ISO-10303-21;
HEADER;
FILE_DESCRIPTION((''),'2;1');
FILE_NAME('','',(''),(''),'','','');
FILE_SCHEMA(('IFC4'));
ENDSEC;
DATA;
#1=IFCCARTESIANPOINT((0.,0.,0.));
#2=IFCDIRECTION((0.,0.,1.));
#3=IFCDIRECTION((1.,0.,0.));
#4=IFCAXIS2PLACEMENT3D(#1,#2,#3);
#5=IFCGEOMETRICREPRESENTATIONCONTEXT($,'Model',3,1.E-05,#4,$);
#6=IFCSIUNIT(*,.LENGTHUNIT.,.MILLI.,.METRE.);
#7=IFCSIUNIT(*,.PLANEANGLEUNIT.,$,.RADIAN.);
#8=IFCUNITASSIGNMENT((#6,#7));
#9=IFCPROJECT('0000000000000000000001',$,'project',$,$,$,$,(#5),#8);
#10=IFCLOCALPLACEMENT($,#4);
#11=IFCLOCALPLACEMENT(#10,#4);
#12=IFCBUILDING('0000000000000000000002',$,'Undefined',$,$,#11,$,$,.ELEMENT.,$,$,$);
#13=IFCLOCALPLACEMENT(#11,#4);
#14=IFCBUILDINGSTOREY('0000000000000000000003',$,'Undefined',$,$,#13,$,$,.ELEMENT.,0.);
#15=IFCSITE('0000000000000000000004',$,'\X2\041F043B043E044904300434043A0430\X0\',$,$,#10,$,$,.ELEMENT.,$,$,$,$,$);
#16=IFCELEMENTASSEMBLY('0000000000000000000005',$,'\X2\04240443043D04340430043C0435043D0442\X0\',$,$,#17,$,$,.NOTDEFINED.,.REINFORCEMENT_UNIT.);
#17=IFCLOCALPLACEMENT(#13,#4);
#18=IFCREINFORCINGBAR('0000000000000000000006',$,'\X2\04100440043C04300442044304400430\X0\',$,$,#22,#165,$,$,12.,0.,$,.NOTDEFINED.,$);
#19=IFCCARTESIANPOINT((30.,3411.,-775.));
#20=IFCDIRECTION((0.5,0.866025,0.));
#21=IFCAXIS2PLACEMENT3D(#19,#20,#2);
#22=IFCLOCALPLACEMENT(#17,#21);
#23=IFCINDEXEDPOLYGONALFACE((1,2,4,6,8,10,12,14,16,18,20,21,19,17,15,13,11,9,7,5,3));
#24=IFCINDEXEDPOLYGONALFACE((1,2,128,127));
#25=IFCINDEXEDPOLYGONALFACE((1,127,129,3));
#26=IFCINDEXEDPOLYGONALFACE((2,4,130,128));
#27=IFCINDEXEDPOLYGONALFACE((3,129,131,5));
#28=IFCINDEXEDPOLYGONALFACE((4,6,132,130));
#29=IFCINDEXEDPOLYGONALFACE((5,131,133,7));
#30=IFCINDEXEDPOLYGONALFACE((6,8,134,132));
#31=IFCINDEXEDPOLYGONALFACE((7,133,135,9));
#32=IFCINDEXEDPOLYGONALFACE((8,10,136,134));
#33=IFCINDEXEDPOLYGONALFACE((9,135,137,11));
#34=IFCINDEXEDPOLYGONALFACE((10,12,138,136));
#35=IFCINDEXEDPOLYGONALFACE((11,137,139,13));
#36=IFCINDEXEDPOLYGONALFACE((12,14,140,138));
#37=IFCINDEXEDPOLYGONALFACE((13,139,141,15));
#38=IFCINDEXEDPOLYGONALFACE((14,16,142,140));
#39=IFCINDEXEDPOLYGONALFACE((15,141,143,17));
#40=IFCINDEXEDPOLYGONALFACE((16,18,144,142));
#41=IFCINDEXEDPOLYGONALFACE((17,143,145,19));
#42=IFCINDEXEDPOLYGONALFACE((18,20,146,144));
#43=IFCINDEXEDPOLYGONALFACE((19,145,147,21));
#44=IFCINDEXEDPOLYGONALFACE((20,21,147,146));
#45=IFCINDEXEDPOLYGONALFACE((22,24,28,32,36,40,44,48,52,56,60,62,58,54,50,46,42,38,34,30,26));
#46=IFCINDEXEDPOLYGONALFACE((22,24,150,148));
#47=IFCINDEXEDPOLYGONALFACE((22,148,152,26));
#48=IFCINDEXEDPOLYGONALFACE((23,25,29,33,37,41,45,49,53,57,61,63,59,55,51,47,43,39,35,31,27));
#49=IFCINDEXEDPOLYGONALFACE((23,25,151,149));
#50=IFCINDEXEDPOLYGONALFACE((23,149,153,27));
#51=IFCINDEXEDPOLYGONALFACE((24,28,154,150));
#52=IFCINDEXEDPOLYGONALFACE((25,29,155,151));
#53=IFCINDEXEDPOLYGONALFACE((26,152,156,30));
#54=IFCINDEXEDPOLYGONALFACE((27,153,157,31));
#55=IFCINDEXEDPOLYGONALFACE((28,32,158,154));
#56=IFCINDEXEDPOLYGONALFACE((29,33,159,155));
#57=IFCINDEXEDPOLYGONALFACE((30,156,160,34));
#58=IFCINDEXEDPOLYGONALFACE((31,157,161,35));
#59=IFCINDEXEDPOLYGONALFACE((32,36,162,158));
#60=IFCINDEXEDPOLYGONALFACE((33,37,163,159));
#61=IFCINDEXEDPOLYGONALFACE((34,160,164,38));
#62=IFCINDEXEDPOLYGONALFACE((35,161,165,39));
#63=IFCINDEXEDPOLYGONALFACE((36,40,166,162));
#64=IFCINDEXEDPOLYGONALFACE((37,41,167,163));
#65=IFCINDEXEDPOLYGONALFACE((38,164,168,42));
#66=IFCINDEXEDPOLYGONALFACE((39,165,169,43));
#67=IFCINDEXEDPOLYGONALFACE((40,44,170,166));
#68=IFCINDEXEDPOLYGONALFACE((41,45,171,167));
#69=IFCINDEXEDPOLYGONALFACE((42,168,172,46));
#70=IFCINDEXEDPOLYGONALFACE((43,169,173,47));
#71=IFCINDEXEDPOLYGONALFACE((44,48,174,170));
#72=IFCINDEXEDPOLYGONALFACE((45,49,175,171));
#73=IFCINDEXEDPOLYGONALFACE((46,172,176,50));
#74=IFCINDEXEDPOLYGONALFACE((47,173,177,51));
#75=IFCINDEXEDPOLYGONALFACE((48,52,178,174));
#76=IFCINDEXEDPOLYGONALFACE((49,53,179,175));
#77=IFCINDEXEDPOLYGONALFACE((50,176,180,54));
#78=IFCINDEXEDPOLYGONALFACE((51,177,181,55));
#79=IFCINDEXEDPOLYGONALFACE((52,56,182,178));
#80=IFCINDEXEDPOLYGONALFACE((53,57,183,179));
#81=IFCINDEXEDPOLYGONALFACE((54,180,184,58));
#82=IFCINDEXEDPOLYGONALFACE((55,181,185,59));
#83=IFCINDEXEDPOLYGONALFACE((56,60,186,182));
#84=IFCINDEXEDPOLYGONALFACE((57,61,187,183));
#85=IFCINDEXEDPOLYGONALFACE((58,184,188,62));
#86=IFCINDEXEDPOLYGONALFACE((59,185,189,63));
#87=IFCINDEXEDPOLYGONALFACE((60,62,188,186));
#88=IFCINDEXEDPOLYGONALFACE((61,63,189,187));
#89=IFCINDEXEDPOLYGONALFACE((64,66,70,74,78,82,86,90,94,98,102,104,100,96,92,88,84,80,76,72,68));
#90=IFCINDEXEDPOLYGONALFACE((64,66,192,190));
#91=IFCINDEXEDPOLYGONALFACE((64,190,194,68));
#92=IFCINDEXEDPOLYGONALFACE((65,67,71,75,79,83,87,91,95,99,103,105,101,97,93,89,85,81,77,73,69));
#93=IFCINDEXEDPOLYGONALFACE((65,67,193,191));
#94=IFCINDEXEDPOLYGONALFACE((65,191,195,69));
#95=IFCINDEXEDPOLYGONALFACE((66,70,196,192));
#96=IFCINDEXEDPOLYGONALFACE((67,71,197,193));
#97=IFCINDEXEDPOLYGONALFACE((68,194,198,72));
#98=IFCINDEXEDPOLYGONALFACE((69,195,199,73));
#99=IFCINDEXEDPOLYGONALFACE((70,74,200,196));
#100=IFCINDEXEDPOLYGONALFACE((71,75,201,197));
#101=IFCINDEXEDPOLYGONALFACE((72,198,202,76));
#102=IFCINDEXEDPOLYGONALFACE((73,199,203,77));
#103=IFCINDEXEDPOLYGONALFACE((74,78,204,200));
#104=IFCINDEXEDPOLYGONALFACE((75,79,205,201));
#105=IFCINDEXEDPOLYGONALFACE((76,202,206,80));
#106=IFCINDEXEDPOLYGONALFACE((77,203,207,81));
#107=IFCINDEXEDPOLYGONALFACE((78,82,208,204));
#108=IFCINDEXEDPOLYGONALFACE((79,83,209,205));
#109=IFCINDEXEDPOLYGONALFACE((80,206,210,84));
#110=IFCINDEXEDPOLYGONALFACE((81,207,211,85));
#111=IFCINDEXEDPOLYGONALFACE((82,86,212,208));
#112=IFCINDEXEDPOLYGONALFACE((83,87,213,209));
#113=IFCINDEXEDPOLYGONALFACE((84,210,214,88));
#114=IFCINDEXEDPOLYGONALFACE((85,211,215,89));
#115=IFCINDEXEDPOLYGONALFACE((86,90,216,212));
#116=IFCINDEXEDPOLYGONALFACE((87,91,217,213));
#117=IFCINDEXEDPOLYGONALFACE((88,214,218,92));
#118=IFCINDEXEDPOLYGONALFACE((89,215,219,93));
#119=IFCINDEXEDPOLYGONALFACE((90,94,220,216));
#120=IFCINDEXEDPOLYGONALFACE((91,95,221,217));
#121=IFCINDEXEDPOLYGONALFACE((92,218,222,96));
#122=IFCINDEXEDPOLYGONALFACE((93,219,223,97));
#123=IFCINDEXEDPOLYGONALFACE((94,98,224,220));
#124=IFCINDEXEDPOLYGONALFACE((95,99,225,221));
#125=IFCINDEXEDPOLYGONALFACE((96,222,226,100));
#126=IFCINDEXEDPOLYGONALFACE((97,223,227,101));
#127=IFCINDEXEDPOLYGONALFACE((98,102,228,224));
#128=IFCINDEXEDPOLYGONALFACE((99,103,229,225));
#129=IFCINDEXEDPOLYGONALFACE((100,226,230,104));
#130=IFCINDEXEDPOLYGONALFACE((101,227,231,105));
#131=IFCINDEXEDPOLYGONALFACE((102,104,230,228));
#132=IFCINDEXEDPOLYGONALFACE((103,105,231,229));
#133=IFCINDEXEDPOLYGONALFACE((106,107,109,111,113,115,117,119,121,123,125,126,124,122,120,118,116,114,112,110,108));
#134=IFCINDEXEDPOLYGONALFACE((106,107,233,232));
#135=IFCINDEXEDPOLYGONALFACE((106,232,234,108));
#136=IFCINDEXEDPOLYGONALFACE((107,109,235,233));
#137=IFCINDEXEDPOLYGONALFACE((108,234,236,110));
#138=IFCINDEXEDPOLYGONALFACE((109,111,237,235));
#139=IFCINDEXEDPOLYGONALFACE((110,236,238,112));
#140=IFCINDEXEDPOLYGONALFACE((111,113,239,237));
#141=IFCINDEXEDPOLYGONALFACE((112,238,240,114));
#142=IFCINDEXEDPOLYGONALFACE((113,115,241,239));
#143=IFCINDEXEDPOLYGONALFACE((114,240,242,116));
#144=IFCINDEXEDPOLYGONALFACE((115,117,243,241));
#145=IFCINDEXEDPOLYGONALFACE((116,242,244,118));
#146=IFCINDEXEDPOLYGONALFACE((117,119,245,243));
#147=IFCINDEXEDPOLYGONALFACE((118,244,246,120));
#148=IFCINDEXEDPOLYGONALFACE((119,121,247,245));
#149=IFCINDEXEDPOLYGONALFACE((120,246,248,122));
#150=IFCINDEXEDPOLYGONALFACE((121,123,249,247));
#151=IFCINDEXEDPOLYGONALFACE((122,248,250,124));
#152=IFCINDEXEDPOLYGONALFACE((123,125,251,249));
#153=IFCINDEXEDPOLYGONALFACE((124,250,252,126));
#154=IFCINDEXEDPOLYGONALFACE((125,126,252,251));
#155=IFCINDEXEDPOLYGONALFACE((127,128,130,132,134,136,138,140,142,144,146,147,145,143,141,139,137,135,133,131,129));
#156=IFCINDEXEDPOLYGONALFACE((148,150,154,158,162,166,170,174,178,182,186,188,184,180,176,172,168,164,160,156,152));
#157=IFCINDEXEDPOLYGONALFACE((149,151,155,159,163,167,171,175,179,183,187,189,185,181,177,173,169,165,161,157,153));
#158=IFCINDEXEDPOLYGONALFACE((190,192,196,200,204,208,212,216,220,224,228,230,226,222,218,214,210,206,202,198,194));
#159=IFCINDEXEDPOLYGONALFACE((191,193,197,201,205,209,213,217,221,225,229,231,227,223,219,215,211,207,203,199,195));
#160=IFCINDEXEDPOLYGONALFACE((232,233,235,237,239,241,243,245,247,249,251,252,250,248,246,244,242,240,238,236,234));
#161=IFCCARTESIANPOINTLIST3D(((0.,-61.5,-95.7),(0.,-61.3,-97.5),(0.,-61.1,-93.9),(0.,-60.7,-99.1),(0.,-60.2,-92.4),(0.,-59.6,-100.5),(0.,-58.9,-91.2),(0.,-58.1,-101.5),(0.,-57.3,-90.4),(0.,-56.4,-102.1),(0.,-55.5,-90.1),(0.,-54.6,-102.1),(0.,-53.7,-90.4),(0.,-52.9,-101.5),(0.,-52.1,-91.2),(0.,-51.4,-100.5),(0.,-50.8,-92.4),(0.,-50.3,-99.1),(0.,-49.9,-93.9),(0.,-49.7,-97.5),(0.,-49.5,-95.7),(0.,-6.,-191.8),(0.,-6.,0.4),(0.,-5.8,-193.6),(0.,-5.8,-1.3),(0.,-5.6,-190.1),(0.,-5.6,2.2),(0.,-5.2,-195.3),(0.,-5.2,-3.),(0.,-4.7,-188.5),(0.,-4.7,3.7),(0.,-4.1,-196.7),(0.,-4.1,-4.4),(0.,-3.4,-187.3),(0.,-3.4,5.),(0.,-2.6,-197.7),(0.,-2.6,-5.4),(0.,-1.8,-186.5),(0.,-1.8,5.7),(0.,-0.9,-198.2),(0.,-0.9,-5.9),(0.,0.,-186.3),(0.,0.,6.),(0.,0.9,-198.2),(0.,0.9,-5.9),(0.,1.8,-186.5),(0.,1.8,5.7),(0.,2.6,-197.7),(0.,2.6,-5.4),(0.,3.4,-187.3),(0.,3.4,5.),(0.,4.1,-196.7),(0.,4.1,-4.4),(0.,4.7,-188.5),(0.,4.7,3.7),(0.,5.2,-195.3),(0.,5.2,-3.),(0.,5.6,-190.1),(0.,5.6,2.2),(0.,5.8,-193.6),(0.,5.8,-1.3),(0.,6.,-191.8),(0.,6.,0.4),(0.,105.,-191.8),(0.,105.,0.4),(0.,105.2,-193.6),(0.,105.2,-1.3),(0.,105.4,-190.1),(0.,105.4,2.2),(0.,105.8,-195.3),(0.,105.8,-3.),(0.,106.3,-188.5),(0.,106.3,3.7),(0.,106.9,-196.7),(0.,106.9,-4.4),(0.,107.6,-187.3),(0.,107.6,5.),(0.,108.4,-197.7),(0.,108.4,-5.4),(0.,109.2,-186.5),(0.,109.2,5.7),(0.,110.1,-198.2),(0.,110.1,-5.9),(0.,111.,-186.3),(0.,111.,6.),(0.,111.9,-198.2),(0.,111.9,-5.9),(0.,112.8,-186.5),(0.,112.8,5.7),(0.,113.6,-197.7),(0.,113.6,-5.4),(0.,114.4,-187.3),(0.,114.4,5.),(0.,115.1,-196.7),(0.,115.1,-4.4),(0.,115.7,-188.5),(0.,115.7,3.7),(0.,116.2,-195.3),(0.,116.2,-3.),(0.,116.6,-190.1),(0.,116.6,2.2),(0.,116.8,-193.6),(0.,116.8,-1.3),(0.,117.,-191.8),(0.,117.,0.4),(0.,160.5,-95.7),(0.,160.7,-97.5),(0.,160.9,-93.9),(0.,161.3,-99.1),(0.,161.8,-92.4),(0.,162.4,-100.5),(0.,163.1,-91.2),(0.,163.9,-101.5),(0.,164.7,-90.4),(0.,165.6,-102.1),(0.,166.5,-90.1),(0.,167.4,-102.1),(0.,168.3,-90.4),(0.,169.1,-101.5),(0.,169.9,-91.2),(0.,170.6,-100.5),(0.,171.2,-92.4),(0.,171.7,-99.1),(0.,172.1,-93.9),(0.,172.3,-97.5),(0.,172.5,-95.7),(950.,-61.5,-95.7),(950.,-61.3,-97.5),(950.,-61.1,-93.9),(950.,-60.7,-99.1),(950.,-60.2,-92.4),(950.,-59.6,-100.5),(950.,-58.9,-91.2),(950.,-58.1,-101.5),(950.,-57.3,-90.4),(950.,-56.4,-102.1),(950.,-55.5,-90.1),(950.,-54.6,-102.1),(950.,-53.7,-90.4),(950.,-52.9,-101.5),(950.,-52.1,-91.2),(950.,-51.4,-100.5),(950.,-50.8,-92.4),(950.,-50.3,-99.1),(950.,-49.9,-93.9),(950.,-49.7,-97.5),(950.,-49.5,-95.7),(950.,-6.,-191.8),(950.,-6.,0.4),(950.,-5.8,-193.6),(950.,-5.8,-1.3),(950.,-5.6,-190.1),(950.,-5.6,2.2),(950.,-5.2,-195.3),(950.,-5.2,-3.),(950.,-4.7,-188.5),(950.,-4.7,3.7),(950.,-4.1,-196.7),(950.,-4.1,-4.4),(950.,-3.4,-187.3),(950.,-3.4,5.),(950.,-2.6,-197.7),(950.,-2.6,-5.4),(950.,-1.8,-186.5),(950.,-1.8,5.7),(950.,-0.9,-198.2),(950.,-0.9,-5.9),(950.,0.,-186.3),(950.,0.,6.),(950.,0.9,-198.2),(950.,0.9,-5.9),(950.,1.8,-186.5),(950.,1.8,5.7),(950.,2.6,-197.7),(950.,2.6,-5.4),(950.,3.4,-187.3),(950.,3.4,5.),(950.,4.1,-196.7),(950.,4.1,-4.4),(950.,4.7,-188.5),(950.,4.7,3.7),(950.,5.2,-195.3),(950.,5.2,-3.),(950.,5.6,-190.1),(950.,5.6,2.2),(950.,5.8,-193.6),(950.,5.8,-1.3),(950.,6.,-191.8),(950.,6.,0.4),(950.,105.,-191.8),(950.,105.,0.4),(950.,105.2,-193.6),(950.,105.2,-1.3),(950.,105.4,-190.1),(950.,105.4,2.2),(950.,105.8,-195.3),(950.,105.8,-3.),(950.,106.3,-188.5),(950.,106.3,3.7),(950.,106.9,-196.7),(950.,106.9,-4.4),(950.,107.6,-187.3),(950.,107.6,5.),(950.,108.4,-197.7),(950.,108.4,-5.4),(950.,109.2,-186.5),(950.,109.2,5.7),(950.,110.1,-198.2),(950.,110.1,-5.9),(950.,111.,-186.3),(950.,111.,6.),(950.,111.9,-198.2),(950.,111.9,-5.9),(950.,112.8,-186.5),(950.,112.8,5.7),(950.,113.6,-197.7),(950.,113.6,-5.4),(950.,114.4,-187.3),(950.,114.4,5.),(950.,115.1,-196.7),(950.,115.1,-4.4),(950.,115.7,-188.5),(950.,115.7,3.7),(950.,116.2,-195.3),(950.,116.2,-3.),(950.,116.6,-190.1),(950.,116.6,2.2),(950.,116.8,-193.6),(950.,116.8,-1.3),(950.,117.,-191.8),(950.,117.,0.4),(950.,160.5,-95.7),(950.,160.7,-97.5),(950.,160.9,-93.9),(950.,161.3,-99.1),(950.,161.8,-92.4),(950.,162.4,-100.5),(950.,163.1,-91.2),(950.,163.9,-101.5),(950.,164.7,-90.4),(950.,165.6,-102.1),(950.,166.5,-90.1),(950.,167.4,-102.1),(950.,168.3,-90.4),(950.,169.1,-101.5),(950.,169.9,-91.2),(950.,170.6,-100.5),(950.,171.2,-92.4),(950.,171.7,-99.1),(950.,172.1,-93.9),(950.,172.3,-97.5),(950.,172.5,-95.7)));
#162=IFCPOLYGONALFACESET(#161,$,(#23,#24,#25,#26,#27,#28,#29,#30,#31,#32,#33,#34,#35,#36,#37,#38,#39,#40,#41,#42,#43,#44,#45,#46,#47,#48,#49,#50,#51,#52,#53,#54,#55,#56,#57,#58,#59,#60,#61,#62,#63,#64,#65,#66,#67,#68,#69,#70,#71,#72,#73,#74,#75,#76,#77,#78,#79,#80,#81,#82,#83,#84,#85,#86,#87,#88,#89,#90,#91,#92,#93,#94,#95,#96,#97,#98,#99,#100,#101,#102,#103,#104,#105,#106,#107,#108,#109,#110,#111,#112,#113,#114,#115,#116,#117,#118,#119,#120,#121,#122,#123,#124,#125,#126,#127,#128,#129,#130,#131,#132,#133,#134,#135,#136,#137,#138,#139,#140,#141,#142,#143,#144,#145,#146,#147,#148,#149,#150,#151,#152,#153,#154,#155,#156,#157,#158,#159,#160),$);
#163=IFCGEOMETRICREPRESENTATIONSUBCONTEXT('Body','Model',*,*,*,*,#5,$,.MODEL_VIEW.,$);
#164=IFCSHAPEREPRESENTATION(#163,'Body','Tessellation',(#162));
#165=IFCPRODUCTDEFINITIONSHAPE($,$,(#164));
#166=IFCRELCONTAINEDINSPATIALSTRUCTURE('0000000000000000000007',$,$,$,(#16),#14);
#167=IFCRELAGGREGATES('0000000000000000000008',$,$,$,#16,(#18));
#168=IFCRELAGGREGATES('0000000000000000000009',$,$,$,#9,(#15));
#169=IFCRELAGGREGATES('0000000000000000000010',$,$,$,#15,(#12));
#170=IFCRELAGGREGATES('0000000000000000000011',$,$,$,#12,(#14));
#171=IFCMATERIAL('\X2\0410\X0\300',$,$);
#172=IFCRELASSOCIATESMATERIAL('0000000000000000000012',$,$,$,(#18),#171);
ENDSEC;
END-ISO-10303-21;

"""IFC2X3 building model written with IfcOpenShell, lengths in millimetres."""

from ifc_helpers import new_model, entity, si_unit, frame, origin_with_axes, place, context, subcontext, project, spatial, source, transform, mapped, material, element, aggregate, save


model = new_model("IFC2X3")

# Units and contexts
model_context = context("Model", 3, precision=1e-05, world=origin_with_axes())
body_context = subcontext(model_context, "Body", "Model", "MODEL_VIEW")
ifc_project = project(units=[si_unit("LENGTHUNIT", "METRE", prefix="MILLI"), si_unit("PLANEANGLEUNIT", "RADIAN")], contexts=[model_context])

# Site, building, storey
site_placement = place(None, origin_with_axes())
site = spatial("IfcSite", under=ifc_project, at=site_placement, Name="Площадка", CompositionType="ELEMENT")
building_placement = place(site_placement, origin_with_axes())
building = spatial("IfcBuilding", under=site, at=building_placement, Name="Undefined", CompositionType="ELEMENT")
storey_placement = place(building_placement, origin_with_axes())
storey = spatial("IfcBuildingStorey", under=building, at=storey_placement, Name="Undefined", CompositionType="ELEMENT", Elevation=0.0)

# Element assembly, reinforcing bar
ifc_material_1 = material(Name="А300")
assembly_1_placement = place(storey_placement, origin_with_axes())
assembly_1 = element("IfcElementAssembly", 1, at=assembly_1_placement, inside=storey, Name="Фундамент", AssemblyPlace="NOTDEFINED", PredefinedType="REINFORCEMENT_UNIT")
shared_shape_1 = source(origin_with_axes(), body_context, "Body", "AdvancedSweptSolid", [
    entity("IfcSweptDiskSolid", entity("IfcTrimmedCurve", entity("IfcLine", entity("IfcCartesianPoint", [0.0, 0.0, 0.0]), entity("IfcVector", entity("IfcDirection", [1.0, 0.0, 0.0]), 1.0)), [entity("IfcParameterValue", 0.0)], [entity("IfcParameterValue", 950.0)], True, "PARAMETER"), 6.0, None, 0.0, 950.0),
])
shared_shape_2 = source(origin_with_axes(), body_context, "Body", "AdvancedSweptSolid", [
    entity("IfcSweptDiskSolid", entity("IfcTrimmedCurve", entity("IfcLine", entity("IfcCartesianPoint", [0.0, 0.0, 0.0]), entity("IfcVector", entity("IfcDirection", [1.0, 0.0, 0.0]), 1.0)), [entity("IfcParameterValue", 0.0)], [entity("IfcParameterValue", 950.0)], True, "PARAMETER"), 6.0, None, 0.0, 950.0),
])
shared_shape_3 = source(origin_with_axes(), body_context, "Body", "AdvancedSweptSolid", [
    entity("IfcSweptDiskSolid", entity("IfcTrimmedCurve", entity("IfcLine", entity("IfcCartesianPoint", [0.0, 0.0, 0.0]), entity("IfcVector", entity("IfcDirection", [1.0, 0.0, 0.0]), 1.0)), [entity("IfcParameterValue", 0.0)], [entity("IfcParameterValue", 950.0)], True, "PARAMETER"), 6.0, None, 0.0, 950.0),
])
shared_shape_4 = source(origin_with_axes(), body_context, "Body", "AdvancedSweptSolid", [
    entity("IfcSweptDiskSolid", entity("IfcTrimmedCurve", entity("IfcLine", entity("IfcCartesianPoint", [0.0, 0.0, 0.0]), entity("IfcVector", entity("IfcDirection", [1.0, 0.0, 0.0]), 1.0)), [entity("IfcParameterValue", 0.0)], [entity("IfcParameterValue", 950.0)], True, "PARAMETER"), 6.0, None, 0.0, 950.0),
])
shared_shape_5 = source(origin_with_axes(), body_context, "Body", "AdvancedSweptSolid", [
    entity("IfcSweptDiskSolid", entity("IfcTrimmedCurve", entity("IfcLine", entity("IfcCartesianPoint", [0.0, 0.0, 0.0]), entity("IfcVector", entity("IfcDirection", [1.0, 0.0, 0.0]), 1.0)), [entity("IfcParameterValue", 0.0)], [entity("IfcParameterValue", 950.0)], True, "PARAMETER"), 6.0, None, 0.0, 950.0),
])
shared_shape_6 = source(origin_with_axes(), body_context, "Body", "AdvancedSweptSolid", [
    entity("IfcSweptDiskSolid", entity("IfcTrimmedCurve", entity("IfcLine", entity("IfcCartesianPoint", [0.0, 0.0, 0.0]), entity("IfcVector", entity("IfcDirection", [1.0, 0.0, 0.0]), 1.0)), [entity("IfcParameterValue", 0.0)], [entity("IfcParameterValue", 950.0)], True, "PARAMETER"), 6.0, None, 0.0, 950.0),
])
reinforcing_bar_1_placement = place(assembly_1_placement, frame((30.0, 3411.0, -775.0), z_axis=(0.5, 0.866025, 0.0), x_axis=(0.0, 0.0, 1.0)))
reinforcing_bar_1 = element("IfcReinforcingBar", 2, at=reinforcing_bar_1_placement, material=ifc_material_1, Name="Арматура", BarRole="NOTDEFINED", CrossSectionArea=0.0, NominalDiameter=12.0, context=body_context, shape_type="MappedRepresentation", body=[
    mapped(shared_shape_1, transform((0.0, 0.0, 0.0))),
    mapped(shared_shape_2, transform((0.0, -55.5, -96.1))),
    mapped(shared_shape_3, transform((0.0, 0.0, -192.3))),
    mapped(shared_shape_4, transform((0.0, 111.0, -192.3))),
    mapped(shared_shape_5, transform((0.0, 166.5, -96.1))),
    mapped(shared_shape_6, transform((0.0, 111.0, 0.0))),
])
aggregate(assembly_1, [reinforcing_bar_1])

save(model, "model.ifc")
